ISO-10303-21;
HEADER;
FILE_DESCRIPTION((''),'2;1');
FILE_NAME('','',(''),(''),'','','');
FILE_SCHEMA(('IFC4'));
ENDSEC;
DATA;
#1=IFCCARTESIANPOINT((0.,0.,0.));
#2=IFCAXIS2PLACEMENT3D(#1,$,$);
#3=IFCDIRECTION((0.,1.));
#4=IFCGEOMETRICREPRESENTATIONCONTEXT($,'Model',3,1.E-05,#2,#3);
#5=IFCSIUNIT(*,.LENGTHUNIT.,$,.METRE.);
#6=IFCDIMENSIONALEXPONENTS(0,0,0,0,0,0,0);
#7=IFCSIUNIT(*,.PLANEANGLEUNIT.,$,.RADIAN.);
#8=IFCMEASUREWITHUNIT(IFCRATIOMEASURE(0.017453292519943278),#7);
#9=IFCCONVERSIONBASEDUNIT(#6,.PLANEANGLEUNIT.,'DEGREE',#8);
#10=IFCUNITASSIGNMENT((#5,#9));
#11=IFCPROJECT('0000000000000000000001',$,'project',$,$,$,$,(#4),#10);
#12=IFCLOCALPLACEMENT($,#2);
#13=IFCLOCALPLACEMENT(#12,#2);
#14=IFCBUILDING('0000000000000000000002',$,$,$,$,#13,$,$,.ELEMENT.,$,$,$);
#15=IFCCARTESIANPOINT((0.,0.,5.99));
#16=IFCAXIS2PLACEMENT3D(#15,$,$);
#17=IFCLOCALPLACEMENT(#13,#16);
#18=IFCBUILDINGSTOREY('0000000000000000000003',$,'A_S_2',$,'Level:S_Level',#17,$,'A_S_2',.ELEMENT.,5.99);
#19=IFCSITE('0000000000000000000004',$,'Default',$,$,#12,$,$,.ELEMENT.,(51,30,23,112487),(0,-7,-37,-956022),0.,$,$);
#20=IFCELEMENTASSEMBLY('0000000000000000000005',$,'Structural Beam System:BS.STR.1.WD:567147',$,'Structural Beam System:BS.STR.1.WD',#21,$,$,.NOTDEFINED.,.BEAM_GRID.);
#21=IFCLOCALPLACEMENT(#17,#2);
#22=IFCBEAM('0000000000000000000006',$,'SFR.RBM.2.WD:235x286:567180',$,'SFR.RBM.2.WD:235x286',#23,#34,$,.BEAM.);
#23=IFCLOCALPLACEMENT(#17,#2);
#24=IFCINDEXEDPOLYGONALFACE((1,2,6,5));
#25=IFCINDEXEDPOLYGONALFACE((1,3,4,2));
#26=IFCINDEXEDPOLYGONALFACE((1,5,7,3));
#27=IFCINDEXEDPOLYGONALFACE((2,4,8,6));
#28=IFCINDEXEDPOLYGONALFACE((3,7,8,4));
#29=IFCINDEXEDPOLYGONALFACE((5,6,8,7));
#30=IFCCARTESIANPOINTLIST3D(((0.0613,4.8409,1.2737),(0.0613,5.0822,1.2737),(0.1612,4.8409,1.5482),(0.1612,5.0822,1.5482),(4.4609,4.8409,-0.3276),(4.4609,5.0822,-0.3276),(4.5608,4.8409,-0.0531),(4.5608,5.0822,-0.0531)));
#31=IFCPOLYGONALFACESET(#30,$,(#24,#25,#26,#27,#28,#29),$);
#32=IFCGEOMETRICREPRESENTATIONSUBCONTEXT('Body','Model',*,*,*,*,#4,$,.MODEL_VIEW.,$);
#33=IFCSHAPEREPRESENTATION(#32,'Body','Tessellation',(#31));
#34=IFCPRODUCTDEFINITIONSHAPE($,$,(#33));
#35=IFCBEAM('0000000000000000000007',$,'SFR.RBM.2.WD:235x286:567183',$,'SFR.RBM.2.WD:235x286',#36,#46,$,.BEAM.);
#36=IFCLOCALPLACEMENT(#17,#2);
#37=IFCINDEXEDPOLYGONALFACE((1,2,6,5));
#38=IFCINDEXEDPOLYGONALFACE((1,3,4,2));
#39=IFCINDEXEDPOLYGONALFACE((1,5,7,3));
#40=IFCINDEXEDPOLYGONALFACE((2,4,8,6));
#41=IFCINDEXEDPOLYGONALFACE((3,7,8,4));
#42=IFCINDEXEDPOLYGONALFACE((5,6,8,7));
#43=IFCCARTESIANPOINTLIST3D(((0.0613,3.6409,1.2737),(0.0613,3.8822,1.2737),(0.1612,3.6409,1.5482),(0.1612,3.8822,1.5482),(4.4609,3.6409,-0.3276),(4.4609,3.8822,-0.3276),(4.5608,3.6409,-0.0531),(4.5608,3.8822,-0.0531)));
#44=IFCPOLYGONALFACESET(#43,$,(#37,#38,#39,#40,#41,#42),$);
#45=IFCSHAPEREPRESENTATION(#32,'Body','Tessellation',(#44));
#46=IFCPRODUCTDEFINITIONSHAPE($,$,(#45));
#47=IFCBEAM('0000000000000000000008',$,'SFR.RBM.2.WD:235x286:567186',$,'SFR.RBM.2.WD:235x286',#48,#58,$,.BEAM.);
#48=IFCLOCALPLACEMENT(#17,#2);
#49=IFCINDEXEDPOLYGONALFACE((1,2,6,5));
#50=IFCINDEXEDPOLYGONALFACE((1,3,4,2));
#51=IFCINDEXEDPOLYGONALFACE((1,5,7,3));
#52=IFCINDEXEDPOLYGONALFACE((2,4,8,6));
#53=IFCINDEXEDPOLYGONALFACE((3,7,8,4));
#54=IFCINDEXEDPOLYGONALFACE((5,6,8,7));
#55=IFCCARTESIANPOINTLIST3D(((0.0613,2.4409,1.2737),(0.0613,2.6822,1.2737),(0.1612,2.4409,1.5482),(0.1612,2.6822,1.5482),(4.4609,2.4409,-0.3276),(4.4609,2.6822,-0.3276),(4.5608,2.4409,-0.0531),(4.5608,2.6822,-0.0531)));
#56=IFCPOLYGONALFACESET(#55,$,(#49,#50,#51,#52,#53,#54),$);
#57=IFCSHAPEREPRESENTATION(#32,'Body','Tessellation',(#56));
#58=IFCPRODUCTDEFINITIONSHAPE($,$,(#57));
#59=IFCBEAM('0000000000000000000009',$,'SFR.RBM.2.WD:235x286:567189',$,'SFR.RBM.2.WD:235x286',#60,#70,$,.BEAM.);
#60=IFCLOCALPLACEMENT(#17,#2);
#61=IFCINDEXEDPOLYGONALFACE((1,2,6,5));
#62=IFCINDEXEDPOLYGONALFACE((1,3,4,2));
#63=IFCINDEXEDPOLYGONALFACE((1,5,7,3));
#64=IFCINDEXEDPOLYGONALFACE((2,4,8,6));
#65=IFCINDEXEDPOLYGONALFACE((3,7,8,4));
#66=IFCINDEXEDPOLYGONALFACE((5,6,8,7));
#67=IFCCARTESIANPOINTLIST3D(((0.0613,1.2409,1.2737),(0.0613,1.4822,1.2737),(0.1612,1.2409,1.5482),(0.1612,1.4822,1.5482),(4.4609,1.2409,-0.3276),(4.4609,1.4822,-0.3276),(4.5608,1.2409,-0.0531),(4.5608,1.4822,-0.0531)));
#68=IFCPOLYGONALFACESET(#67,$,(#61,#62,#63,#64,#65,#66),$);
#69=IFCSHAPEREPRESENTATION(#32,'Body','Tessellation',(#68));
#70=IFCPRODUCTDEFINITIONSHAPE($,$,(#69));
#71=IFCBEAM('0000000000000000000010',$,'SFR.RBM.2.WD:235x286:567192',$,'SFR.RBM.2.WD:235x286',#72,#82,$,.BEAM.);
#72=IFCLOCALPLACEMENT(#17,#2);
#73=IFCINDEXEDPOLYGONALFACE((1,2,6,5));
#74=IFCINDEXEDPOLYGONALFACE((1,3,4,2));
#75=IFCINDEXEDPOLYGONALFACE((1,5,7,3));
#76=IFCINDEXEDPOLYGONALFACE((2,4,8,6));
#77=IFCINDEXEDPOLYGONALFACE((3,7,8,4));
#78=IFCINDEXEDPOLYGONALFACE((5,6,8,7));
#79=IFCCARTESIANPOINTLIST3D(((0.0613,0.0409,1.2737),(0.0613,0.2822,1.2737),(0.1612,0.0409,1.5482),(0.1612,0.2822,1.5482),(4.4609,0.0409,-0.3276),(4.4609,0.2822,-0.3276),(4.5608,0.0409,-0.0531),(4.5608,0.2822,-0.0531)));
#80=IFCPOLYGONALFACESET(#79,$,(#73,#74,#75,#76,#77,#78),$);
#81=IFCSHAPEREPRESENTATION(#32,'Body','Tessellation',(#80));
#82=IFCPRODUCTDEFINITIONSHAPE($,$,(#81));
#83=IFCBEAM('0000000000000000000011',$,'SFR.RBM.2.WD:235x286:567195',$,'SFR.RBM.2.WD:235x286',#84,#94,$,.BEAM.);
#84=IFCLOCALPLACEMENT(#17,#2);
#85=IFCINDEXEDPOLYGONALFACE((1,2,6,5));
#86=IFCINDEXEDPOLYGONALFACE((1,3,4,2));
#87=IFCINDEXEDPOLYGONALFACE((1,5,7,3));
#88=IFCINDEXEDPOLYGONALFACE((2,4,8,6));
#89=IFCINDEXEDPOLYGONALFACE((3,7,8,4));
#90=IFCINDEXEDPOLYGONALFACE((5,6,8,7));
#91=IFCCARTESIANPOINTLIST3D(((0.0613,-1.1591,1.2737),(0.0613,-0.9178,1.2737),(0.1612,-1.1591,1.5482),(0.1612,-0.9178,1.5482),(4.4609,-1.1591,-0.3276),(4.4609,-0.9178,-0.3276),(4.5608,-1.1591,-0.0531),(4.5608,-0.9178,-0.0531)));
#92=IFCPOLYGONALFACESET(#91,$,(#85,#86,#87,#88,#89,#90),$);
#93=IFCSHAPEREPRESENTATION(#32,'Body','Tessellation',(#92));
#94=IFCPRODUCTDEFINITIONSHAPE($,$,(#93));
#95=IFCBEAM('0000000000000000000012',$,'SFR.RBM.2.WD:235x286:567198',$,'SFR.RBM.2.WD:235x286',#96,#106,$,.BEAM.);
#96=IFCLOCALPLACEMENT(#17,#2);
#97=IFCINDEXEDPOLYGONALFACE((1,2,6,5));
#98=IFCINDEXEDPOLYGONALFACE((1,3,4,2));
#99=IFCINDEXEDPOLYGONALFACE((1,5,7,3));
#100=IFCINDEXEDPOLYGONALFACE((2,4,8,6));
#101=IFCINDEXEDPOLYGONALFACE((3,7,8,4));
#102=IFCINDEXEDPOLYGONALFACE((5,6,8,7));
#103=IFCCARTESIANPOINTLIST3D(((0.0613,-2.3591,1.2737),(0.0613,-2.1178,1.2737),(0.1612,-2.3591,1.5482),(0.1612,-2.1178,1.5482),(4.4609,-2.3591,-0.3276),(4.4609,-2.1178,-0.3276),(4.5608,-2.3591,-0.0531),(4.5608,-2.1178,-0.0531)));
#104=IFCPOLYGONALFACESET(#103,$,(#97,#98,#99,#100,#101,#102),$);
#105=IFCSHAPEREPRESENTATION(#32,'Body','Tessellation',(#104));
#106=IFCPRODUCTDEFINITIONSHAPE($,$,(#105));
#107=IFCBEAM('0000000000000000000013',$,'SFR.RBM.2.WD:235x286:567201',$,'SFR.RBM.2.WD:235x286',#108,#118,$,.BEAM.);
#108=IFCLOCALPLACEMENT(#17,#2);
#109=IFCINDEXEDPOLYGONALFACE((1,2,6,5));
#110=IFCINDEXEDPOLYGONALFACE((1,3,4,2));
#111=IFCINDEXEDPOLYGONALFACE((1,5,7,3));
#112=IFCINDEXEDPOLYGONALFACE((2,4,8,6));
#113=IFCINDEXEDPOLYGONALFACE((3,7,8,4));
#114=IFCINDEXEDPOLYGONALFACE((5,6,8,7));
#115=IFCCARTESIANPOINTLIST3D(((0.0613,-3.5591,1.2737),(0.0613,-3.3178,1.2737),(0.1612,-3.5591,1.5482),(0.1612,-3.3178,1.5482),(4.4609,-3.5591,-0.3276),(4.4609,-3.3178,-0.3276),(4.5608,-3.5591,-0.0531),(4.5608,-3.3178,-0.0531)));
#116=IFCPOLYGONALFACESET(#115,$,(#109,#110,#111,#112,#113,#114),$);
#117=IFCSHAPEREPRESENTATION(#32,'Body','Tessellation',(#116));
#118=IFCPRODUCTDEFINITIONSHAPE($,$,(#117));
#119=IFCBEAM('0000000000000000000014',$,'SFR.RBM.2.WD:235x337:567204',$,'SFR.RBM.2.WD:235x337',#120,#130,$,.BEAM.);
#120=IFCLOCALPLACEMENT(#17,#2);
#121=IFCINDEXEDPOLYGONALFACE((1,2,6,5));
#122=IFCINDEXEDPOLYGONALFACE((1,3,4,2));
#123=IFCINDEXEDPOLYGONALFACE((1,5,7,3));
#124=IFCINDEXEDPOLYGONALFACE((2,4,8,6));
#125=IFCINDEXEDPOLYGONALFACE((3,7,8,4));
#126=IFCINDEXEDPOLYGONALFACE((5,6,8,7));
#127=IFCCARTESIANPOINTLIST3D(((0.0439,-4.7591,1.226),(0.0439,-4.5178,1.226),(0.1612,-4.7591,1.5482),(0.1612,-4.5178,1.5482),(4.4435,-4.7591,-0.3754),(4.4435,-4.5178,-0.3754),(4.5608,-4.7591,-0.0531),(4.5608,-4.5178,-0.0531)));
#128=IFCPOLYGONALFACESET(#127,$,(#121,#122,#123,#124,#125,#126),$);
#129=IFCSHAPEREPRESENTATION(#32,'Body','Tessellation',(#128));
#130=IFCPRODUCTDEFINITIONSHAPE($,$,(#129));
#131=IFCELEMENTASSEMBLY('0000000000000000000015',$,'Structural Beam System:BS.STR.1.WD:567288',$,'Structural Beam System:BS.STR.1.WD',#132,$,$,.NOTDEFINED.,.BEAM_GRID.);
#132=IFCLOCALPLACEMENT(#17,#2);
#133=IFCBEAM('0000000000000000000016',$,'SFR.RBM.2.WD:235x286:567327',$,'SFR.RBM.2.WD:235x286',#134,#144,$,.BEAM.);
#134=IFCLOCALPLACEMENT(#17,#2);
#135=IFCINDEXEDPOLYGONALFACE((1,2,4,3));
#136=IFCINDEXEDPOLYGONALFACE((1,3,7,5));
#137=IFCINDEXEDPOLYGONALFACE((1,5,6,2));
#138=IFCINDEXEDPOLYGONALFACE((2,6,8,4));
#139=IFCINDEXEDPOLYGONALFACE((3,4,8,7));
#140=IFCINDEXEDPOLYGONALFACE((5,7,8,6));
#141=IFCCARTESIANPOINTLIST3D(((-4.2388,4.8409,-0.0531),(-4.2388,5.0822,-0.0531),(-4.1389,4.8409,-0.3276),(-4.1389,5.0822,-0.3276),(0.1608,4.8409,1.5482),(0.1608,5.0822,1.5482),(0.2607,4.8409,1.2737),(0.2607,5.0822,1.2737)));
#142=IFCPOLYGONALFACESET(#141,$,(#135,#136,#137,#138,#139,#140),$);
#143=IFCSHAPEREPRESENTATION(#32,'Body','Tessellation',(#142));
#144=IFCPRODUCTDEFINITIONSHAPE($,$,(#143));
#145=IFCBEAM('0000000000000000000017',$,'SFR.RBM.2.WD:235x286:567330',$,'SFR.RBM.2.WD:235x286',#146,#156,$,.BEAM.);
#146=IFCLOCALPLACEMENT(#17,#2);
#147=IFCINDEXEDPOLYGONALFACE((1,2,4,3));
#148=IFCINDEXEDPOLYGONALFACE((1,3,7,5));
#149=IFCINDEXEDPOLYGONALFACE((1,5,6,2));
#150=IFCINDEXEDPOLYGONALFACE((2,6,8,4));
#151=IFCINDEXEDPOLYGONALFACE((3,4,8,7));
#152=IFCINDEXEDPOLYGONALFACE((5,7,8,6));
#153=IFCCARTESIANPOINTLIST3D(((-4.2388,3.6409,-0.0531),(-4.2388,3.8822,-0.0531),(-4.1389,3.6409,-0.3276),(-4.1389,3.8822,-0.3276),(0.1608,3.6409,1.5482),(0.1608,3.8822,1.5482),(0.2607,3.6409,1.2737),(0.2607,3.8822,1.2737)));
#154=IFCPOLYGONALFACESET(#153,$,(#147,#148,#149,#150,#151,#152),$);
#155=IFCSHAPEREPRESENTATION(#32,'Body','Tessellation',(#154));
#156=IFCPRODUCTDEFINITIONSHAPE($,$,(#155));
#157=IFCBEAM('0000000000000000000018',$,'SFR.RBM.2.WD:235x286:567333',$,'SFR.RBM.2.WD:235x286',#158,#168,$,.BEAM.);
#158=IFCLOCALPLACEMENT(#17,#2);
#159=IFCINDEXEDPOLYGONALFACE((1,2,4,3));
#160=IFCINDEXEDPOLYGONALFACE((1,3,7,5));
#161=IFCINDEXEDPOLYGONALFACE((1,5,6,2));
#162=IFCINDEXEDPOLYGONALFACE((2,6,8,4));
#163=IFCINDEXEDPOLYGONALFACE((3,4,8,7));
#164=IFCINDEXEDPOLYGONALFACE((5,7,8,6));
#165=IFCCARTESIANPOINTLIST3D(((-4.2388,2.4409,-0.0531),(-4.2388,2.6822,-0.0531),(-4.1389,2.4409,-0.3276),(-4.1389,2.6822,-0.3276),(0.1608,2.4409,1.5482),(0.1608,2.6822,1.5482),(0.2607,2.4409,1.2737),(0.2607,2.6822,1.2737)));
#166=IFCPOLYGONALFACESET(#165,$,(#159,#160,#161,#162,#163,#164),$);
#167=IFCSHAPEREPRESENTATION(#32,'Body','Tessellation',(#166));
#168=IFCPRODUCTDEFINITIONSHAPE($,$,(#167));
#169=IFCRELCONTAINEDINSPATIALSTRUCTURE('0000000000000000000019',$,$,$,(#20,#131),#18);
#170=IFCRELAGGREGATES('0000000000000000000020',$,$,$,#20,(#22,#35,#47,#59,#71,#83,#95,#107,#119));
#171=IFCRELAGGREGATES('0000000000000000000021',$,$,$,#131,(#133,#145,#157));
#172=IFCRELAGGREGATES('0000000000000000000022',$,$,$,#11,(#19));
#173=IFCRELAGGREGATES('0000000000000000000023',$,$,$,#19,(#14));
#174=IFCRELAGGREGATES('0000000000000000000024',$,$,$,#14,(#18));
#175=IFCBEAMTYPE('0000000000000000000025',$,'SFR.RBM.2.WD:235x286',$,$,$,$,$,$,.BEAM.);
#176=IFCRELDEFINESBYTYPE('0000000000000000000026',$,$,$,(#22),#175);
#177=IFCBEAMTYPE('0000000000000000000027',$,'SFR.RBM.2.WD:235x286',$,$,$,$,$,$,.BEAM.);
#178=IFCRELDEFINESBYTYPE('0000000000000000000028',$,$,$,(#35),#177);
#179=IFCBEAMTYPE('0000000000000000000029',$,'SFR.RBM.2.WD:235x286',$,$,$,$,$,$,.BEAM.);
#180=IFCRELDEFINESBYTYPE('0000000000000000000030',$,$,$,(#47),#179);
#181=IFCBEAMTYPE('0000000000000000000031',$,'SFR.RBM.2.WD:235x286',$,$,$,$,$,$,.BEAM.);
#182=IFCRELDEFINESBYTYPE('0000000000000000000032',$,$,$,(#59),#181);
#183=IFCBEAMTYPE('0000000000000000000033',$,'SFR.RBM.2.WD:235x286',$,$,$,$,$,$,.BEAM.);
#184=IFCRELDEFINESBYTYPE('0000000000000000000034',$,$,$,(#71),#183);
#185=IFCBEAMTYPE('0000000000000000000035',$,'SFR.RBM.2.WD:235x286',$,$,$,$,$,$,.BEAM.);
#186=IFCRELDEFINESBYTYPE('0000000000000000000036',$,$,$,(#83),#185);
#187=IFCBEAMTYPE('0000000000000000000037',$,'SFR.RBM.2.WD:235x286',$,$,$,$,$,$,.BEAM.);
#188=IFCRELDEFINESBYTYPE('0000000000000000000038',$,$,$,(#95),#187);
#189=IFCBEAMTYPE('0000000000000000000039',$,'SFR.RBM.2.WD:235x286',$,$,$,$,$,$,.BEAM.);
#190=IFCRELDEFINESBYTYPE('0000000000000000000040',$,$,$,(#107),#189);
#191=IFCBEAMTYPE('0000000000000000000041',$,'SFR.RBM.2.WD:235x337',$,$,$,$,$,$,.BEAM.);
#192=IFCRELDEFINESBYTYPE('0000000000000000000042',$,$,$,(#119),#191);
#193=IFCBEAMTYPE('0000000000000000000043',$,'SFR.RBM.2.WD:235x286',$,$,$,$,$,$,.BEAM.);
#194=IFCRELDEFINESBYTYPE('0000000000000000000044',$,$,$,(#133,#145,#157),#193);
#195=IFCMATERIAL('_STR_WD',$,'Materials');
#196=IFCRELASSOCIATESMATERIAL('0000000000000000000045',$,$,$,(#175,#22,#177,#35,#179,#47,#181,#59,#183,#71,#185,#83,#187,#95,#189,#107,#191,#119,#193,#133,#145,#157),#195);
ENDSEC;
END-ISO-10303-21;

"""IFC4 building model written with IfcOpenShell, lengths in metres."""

from ifc_helpers import new_model, entity, si_unit, converted_unit, direction, frame, origin, place, context, subcontext, project, spatial, indexed_curve, outline, extrude, source, transform, mapped, material, type_object, type_shapes, element, aggregate, save


model = new_model("IFC4")

# Units and contexts
model_context = context("Model", 3, precision=1e-05, world=origin(), true_north=direction((0.0, 1.0)))
body_context = subcontext(model_context, "Body", "Model", "MODEL_VIEW")
ifc_project = project(units=[si_unit("LENGTHUNIT", "METRE"), converted_unit("PLANEANGLEUNIT", "DEGREE", entity("IfcRatioMeasure", 0.017453292519943278), si_unit("PLANEANGLEUNIT", "RADIAN"), dimensions=[0, 0, 0, 0, 0, 0, 0])], contexts=[model_context])

# Site, building, storey
site_placement = place(None, origin())
site = spatial("IfcSite", under=ifc_project, at=site_placement, Name="Default", CompositionType="ELEMENT", RefLatitude=(51, 30, 23, 112487), RefLongitude=(0, -7, -37, -956022), RefElevation=0.0)
building_placement = place(site_placement, origin())
building = spatial("IfcBuilding", under=site, at=building_placement, CompositionType="ELEMENT")
storey_placement = place(building_placement, frame((0.0, 0.0, 5.99)))
storey = spatial("IfcBuildingStorey", under=building, at=storey_placement, Name="A_S_2", ObjectType="Level:S_Level", LongName="A_S_2", CompositionType="ELEMENT", Elevation=5.99)

# Element assemblies, beams
assembly_1_placement = place(storey_placement, origin())
assembly_1 = element("IfcElementAssembly", 1, at=assembly_1_placement, inside=storey, Name="Structural Beam System:BS.STR.1.WD:567147", ObjectType="Structural Beam System:BS.STR.1.WD", AssemblyPlace="NOTDEFINED", PredefinedType="BEAM_GRID")
ifc_material = material(Name="_STR_WD", Category="Materials")
beam_type_1 = type_object("IfcBeamType", Name="SFR.RBM.2.WD:235x286", PredefinedType="BEAM", material=ifc_material)
shared_shape_1 = source(origin(), body_context, "Body", "SweptSolid", [
    extrude(outline(indexed_curve([(-0.1207, -0.1461), (0.1207, -0.1461), (0.1207, 0.1461), (-0.1207, 0.1461), (-0.1207, -0.1461)], self_intersect=False)), frame((4.5109, 4.9615, 5.7996), z_axis=(-0.939693, 0.0, 0.34202), x_axis=(0.0, -1.0, 0.0)), (0.0, 0.0, 1.0), 4.682),
])
type_shapes(beam_type_1, [shared_shape_1])
beam_1_placement = place(assembly_1_placement, frame((0.0, 0.0, -5.99)))
beam_1 = element("IfcBeam", 2, at=beam_1_placement, type_object=beam_type_1, material=ifc_material, Name="SFR.RBM.2.WD:235x286:567180", ObjectType="SFR.RBM.2.WD:235x286", PredefinedType="BEAM", context=body_context, shape_type="MappedRepresentation", body=[
    mapped(shared_shape_1, transform((0.0, 0.0, 0.0), scale=1.0)),
])
beam_type_2 = type_object("IfcBeamType", Name="SFR.RBM.2.WD:235x286", PredefinedType="BEAM", material=ifc_material)
shared_shape_2 = source(origin(), body_context, "Body", "SweptSolid", [
    extrude(outline(indexed_curve([(-0.1207, -0.1461), (0.1207, -0.1461), (0.1207, 0.1461), (-0.1207, 0.1461), (-0.1207, -0.1461)], self_intersect=False)), frame((4.5109, 3.7615, 5.7996), z_axis=(-0.939693, 0.0, 0.34202), x_axis=(0.0, -1.0, 0.0)), (0.0, 0.0, 1.0), 4.682),
])
type_shapes(beam_type_2, [shared_shape_2])
beam_2_placement = place(assembly_1_placement, frame((0.0, 0.0, -5.99)))
beam_2 = element("IfcBeam", 3, at=beam_2_placement, type_object=beam_type_2, material=ifc_material, Name="SFR.RBM.2.WD:235x286:567183", ObjectType="SFR.RBM.2.WD:235x286", PredefinedType="BEAM", context=body_context, shape_type="MappedRepresentation", body=[
    mapped(shared_shape_2, transform((0.0, 0.0, 0.0), scale=1.0)),
])
beam_type_3 = type_object("IfcBeamType", Name="SFR.RBM.2.WD:235x286", PredefinedType="BEAM", material=ifc_material)
shared_shape_3 = source(origin(), body_context, "Body", "SweptSolid", [
    extrude(outline(indexed_curve([(-0.1207, -0.146), (0.1207, -0.1461), (0.1207, 0.1461), (-0.1207, 0.1461), (-0.1207, -0.146)], self_intersect=False)), frame((4.5109, 2.5615, 5.7996), z_axis=(-0.939693, 0.0, 0.34202), x_axis=(0.0, -1.0, 0.0)), (0.0, 0.0, 1.0), 4.682),
])
type_shapes(beam_type_3, [shared_shape_3])
beam_3_placement = place(assembly_1_placement, frame((0.0, 0.0, -5.99)))
beam_3 = element("IfcBeam", 4, at=beam_3_placement, type_object=beam_type_3, material=ifc_material, Name="SFR.RBM.2.WD:235x286:567186", ObjectType="SFR.RBM.2.WD:235x286", PredefinedType="BEAM", context=body_context, shape_type="MappedRepresentation", body=[
    mapped(shared_shape_3, transform((0.0, 0.0, 0.0), scale=1.0)),
])
beam_type_4 = type_object("IfcBeamType", Name="SFR.RBM.2.WD:235x286", PredefinedType="BEAM", material=ifc_material)
shared_shape_4 = source(origin(), body_context, "Body", "SweptSolid", [
    extrude(outline(indexed_curve([(-0.1207, -0.146), (0.1207, -0.1461), (0.1207, 0.1461), (-0.1207, 0.1461), (-0.1207, -0.146)], self_intersect=False)), frame((4.5109, 1.3615, 5.7996), z_axis=(-0.939693, 0.0, 0.34202), x_axis=(0.0, -1.0, 0.0)), (0.0, 0.0, 1.0), 4.682),
])
type_shapes(beam_type_4, [shared_shape_4])
beam_4_placement = place(assembly_1_placement, frame((0.0, 0.0, -5.99)))
beam_4 = element("IfcBeam", 5, at=beam_4_placement, type_object=beam_type_4, material=ifc_material, Name="SFR.RBM.2.WD:235x286:567189", ObjectType="SFR.RBM.2.WD:235x286", PredefinedType="BEAM", context=body_context, shape_type="MappedRepresentation", body=[
    mapped(shared_shape_4, transform((0.0, 0.0, 0.0), scale=1.0)),
])
beam_type_5 = type_object("IfcBeamType", Name="SFR.RBM.2.WD:235x286", PredefinedType="BEAM", material=ifc_material)
shared_shape_5 = source(origin(), body_context, "Body", "SweptSolid", [
    extrude(outline(indexed_curve([(-0.1207, -0.1461), (0.1207, -0.1461), (0.1207, 0.1461), (-0.1207, 0.1461), (-0.1207, -0.1461)], self_intersect=False)), frame((4.5109, 0.1615, 5.7996), z_axis=(-0.939693, 0.0, 0.34202), x_axis=(0.0, -1.0, 0.0)), (0.0, 0.0, 1.0), 4.682),
])
type_shapes(beam_type_5, [shared_shape_5])
beam_5_placement = place(assembly_1_placement, frame((0.0, 0.0, -5.99)))
beam_5 = element("IfcBeam", 6, at=beam_5_placement, type_object=beam_type_5, material=ifc_material, Name="SFR.RBM.2.WD:235x286:567192", ObjectType="SFR.RBM.2.WD:235x286", PredefinedType="BEAM", context=body_context, shape_type="MappedRepresentation", body=[
    mapped(shared_shape_5, transform((0.0, 0.0, 0.0), scale=1.0)),
])
beam_type_6 = type_object("IfcBeamType", Name="SFR.RBM.2.WD:235x286", PredefinedType="BEAM", material=ifc_material)
shared_shape_6 = source(origin(), body_context, "Body", "SweptSolid", [
    extrude(outline(indexed_curve([(-0.1207, -0.1461), (0.1207, -0.1461), (0.1207, 0.1461), (-0.1207, 0.1461), (-0.1207, -0.1461)], self_intersect=False)), frame((4.5109, -1.0385, 5.7996), z_axis=(-0.939693, 0.0, 0.34202), x_axis=(0.0, -1.0, 0.0)), (0.0, 0.0, 1.0), 4.682),
])
type_shapes(beam_type_6, [shared_shape_6])
beam_6_placement = place(assembly_1_placement, frame((0.0, 0.0, -5.99)))
beam_6 = element("IfcBeam", 7, at=beam_6_placement, type_object=beam_type_6, material=ifc_material, Name="SFR.RBM.2.WD:235x286:567195", ObjectType="SFR.RBM.2.WD:235x286", PredefinedType="BEAM", context=body_context, shape_type="MappedRepresentation", body=[
    mapped(shared_shape_6, transform((0.0, 0.0, 0.0), scale=1.0)),
])
beam_type_7 = type_object("IfcBeamType", Name="SFR.RBM.2.WD:235x286", PredefinedType="BEAM", material=ifc_material)
shared_shape_7 = source(origin(), body_context, "Body", "SweptSolid", [
    extrude(outline(indexed_curve([(-0.1207, -0.1461), (0.1207, -0.1461), (0.1207, 0.1461), (-0.1207, 0.1461), (-0.1207, -0.1461)], self_intersect=False)), frame((4.5109, -2.2385, 5.7996), z_axis=(-0.939693, 0.0, 0.34202), x_axis=(0.0, -1.0, 0.0)), (0.0, 0.0, 1.0), 4.682),
])
type_shapes(beam_type_7, [shared_shape_7])
beam_7_placement = place(assembly_1_placement, frame((0.0, 0.0, -5.99)))
beam_7 = element("IfcBeam", 8, at=beam_7_placement, type_object=beam_type_7, material=ifc_material, Name="SFR.RBM.2.WD:235x286:567198", ObjectType="SFR.RBM.2.WD:235x286", PredefinedType="BEAM", context=body_context, shape_type="MappedRepresentation", body=[
    mapped(shared_shape_7, transform((0.0, 0.0, 0.0), scale=1.0)),
])
beam_type_8 = type_object("IfcBeamType", Name="SFR.RBM.2.WD:235x286", PredefinedType="BEAM", material=ifc_material)
shared_shape_8 = source(origin(), body_context, "Body", "SweptSolid", [
    extrude(outline(indexed_curve([(-0.1207, -0.1461), (0.1207, -0.1461), (0.1207, 0.1461), (-0.1207, 0.1461), (-0.1207, -0.1461)], self_intersect=False)), frame((4.5109, -3.4385, 5.7996), z_axis=(-0.939693, 0.0, 0.34202), x_axis=(0.0, -1.0, 0.0)), (0.0, 0.0, 1.0), 4.682),
])
type_shapes(beam_type_8, [shared_shape_8])
beam_8_placement = place(assembly_1_placement, frame((0.0, 0.0, -5.99)))
beam_8 = element("IfcBeam", 9, at=beam_8_placement, type_object=beam_type_8, material=ifc_material, Name="SFR.RBM.2.WD:235x286:567201", ObjectType="SFR.RBM.2.WD:235x286", PredefinedType="BEAM", context=body_context, shape_type="MappedRepresentation", body=[
    mapped(shared_shape_8, transform((0.0, 0.0, 0.0), scale=1.0)),
])
beam_type_9 = type_object("IfcBeamType", Name="SFR.RBM.2.WD:235x337", PredefinedType="BEAM", material=ifc_material)
shared_shape_9 = source(origin(), body_context, "Body", "SweptSolid", [
    extrude(outline(indexed_curve([(-0.1207, -0.1715), (0.1207, -0.1715), (0.1207, 0.1715), (-0.1207, 0.1715), (-0.1207, -0.1715)], self_intersect=False)), frame((4.5022, -4.6385, 5.7757), z_axis=(-0.939693, 0.0, 0.34202), x_axis=(0.0, -1.0, 0.0)), (0.0, 0.0, 1.0), 4.682),
])
type_shapes(beam_type_9, [shared_shape_9])
beam_9_placement = place(assembly_1_placement, frame((0.0, 0.0, -5.99)))
beam_9 = element("IfcBeam", 10, at=beam_9_placement, type_object=beam_type_9, material=ifc_material, Name="SFR.RBM.2.WD:235x337:567204", ObjectType="SFR.RBM.2.WD:235x337", PredefinedType="BEAM", context=body_context, shape_type="MappedRepresentation", body=[
    mapped(shared_shape_9, transform((0.0, 0.0, 0.0), scale=1.0)),
])
aggregate(assembly_1, [beam_1, beam_2, beam_3, beam_4, beam_5, beam_6, beam_7, beam_8, beam_9])
assembly_2_placement = place(storey_placement, origin())
assembly_2 = element("IfcElementAssembly", 11, at=assembly_2_placement, inside=storey, Name="Structural Beam System:BS.STR.1.WD:567288", ObjectType="Structural Beam System:BS.STR.1.WD", AssemblyPlace="NOTDEFINED", PredefinedType="BEAM_GRID")
beam_type_10 = type_object("IfcBeamType", Name="SFR.RBM.2.WD:235x286", PredefinedType="BEAM", material=ifc_material)
shared_shape_10 = source(origin(), body_context, "Body", "SweptSolid", [
    extrude(outline(indexed_curve([(-0.146, -0.1207), (0.146, -0.1207), (0.146, 0.1207), (-0.146, 0.1207), (-0.146, -0.1207)], self_intersect=False)), frame((-2.341, 0.0, 0.0), z_axis=(1.0, 0.0, 0.0), x_axis=(0.0, 0.0, -1.0)), (0.0, 0.0, 1.0), 4.682),
])
type_shapes(beam_type_10, [shared_shape_10])
beam_10_placement = place(assembly_2_placement, frame((-1.9891, 4.9615, 0.6103), z_axis=(-0.34202, 0.0, 0.939693), x_axis=(-0.939693, 0.0, -0.34202)))
beam_10 = element("IfcBeam", 12, at=beam_10_placement, type_object=beam_type_10, material=ifc_material, Name="SFR.RBM.2.WD:235x286:567327", ObjectType="SFR.RBM.2.WD:235x286", PredefinedType="BEAM", context=body_context, shape_type="MappedRepresentation", body=[
    mapped(shared_shape_10, transform((0.0, 0.0, 0.0), scale=1.0)),
])
beam_11_placement = place(assembly_2_placement, frame((-1.9891, 3.7615, 0.6103), z_axis=(-0.34202, 0.0, 0.939693), x_axis=(-0.939693, 0.0, -0.34202)))
beam_11 = element("IfcBeam", 13, at=beam_11_placement, type_object=beam_type_10, material=ifc_material, Name="SFR.RBM.2.WD:235x286:567330", ObjectType="SFR.RBM.2.WD:235x286", PredefinedType="BEAM", context=body_context, shape_type="MappedRepresentation", body=[
    mapped(shared_shape_10, transform((0.0, 0.0, 0.0), scale=1.0)),
])
beam_12_placement = place(assembly_2_placement, frame((-1.9891, 2.5615, 0.6103), z_axis=(-0.34202, 0.0, 0.939693), x_axis=(-0.939693, 0.0, -0.34202)))
beam_12 = element("IfcBeam", 14, at=beam_12_placement, type_object=beam_type_10, material=ifc_material, Name="SFR.RBM.2.WD:235x286:567333", ObjectType="SFR.RBM.2.WD:235x286", PredefinedType="BEAM", context=body_context, shape_type="MappedRepresentation", body=[
    mapped(shared_shape_10, transform((0.0, 0.0, 0.0), scale=1.0)),
])
aggregate(assembly_2, [beam_10, beam_11, beam_12])

save(model, "model.ifc")
